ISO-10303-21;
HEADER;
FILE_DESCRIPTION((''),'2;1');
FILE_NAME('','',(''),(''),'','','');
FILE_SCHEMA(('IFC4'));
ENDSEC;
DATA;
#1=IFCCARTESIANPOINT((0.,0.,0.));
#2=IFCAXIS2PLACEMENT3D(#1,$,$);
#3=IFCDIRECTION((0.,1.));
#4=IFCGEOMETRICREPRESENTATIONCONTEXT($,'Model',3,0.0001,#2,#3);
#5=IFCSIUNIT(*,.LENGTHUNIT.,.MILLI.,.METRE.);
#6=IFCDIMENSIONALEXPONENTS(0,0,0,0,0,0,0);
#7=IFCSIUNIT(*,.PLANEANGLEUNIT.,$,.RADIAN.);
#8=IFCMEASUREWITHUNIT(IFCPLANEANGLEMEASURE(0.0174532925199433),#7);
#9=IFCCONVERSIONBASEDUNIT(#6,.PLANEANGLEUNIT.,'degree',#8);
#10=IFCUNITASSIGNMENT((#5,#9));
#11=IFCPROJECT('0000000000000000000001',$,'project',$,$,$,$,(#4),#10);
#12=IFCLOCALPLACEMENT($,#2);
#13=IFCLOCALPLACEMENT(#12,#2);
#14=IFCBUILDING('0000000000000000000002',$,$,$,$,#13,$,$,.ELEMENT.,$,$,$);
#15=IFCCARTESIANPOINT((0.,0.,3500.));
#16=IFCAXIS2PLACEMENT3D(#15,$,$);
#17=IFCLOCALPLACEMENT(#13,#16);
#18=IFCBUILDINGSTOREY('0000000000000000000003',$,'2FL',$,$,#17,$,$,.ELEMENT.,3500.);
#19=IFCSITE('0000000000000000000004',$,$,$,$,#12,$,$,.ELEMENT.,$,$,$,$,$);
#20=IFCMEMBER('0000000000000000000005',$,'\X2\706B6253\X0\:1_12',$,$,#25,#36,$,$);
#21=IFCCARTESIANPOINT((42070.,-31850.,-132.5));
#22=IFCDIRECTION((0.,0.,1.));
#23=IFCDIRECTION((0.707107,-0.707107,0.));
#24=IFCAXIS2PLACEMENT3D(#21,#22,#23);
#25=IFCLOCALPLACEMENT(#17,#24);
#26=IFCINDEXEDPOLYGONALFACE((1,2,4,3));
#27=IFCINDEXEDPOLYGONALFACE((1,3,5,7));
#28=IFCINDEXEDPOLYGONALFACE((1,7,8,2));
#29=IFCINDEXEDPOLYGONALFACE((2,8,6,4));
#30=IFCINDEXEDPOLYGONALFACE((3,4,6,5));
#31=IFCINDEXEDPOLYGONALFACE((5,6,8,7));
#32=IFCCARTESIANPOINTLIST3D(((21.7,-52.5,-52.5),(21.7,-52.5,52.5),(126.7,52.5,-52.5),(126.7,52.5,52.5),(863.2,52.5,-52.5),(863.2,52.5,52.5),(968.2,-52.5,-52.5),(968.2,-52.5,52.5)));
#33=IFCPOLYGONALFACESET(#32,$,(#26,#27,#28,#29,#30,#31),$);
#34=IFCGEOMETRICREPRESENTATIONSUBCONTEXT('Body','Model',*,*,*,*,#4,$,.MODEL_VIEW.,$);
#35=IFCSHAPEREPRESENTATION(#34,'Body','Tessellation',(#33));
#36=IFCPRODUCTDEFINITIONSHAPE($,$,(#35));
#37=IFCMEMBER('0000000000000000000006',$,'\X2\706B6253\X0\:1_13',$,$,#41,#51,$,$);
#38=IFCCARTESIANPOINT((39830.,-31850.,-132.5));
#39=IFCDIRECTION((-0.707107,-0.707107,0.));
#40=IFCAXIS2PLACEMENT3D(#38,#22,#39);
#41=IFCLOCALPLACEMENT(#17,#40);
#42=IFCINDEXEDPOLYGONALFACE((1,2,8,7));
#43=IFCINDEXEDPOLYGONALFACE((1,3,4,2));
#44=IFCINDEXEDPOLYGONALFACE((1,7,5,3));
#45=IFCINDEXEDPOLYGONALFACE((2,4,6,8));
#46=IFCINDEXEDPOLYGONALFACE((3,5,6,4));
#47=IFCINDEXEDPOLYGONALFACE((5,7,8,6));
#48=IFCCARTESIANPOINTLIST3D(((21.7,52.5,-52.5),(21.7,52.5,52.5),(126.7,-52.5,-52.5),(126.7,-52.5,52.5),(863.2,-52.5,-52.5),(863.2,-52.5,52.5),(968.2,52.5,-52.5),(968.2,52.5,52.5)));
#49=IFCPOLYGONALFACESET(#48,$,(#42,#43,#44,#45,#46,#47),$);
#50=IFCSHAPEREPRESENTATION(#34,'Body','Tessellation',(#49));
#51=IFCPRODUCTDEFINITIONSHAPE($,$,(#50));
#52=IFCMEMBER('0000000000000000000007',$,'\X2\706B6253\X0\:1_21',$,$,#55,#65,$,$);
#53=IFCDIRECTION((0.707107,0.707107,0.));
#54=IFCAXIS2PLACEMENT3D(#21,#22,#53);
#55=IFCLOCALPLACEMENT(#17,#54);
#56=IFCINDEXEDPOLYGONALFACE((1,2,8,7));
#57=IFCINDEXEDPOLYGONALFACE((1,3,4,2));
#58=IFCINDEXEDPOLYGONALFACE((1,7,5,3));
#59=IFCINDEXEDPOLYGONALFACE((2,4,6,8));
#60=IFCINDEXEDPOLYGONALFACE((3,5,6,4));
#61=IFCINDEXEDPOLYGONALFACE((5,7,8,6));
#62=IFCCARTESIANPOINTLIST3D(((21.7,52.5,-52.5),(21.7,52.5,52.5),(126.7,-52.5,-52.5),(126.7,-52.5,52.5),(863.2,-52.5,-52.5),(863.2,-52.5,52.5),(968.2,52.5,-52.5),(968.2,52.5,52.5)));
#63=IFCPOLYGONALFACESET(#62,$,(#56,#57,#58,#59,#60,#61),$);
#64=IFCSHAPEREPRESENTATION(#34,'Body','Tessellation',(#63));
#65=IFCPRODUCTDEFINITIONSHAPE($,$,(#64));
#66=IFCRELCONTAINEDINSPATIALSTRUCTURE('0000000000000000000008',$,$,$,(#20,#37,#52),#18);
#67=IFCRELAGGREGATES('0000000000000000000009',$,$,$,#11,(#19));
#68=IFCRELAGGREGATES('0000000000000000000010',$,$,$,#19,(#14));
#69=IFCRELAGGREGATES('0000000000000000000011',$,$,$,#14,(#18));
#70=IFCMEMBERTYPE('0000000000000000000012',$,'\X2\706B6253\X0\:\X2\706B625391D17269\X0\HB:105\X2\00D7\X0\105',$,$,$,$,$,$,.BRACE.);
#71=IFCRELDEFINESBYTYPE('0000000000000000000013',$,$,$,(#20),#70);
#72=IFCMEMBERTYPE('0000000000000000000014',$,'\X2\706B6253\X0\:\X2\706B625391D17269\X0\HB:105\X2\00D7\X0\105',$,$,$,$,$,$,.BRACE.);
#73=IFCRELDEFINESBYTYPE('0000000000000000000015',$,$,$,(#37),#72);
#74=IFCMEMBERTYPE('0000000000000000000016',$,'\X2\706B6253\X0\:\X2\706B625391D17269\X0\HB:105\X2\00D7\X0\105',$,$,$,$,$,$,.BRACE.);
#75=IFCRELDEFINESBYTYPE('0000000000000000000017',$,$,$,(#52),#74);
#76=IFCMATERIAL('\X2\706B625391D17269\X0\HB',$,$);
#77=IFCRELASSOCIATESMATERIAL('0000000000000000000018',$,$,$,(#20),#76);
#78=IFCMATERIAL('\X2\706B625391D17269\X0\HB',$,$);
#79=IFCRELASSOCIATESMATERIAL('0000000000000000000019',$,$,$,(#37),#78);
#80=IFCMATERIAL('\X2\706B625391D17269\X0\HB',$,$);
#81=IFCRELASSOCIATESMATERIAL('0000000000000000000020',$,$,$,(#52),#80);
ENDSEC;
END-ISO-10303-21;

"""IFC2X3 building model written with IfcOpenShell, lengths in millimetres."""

from ifc_helpers import new_model, entity, si_unit, converted_unit, direction, frame, origin, place, context, subcontext, project, spatial, polyline, outline, extrude, material, type_object, element, save


model = new_model("IFC2X3")

# Units and contexts
model_context = context("Model", 3, precision=0.0001, world=origin(), true_north=direction((0.0, 1.0)))
body_context = subcontext(model_context, "Body", "Model", "MODEL_VIEW")
ifc_project = project(units=[si_unit("LENGTHUNIT", "METRE", prefix="MILLI"), converted_unit("PLANEANGLEUNIT", "degree", entity("IfcPlaneAngleMeasure", 0.0174532925199433), si_unit("PLANEANGLEUNIT", "RADIAN"), dimensions=[0, 0, 0, 0, 0, 0, 0])], contexts=[model_context])

# Site, building, storey
site_placement = place(None, origin())
site = spatial("IfcSite", under=ifc_project, at=site_placement, CompositionType="ELEMENT")
building_placement = place(site_placement, origin())
building = spatial("IfcBuilding", under=site, at=building_placement, CompositionType="ELEMENT")
storey_placement = place(building_placement, frame((0.0, 0.0, 3500.0)))
storey = spatial("IfcBuildingStorey", under=building, at=storey_placement, Name="2FL", CompositionType="ELEMENT", Elevation=3500.0)

# Members
ifc_material_1 = material(Name="火打金物HB")
member_type_1 = type_object("IfcMemberType", Name="火打:火打金物HB:105×105", PredefinedType="BRACE")
member_1_placement = place(storey_placement, frame((42070.0, -31850.0, -132.5), z_axis=(0.0, 0.0, 1.0), x_axis=(0.707107, -0.707107, 0.0)))
element("IfcMember", 1, at=member_1_placement, inside=storey, type_object=member_type_1, material=ifc_material_1, Name="火打:1_12", context=body_context, shape_type="SweptSolid", body=[
    extrude(outline(polyline([(21.7, -52.5, 0.0), (126.7, 52.5, 0.0), (863.2, 52.5, 0.0), (968.2, -52.5, 0.0), (21.7, -52.5, 0.0)])), frame((0.0, 0.0, -52.5), z_axis=(0.0, 0.0, 1.0), x_axis=(1.0, 0.0, 0.0)), (0.0, 0.0, 1.0), 105.0),
])
ifc_material_2 = material(Name="火打金物HB")
member_type_2 = type_object("IfcMemberType", Name="火打:火打金物HB:105×105", PredefinedType="BRACE")
member_2_placement = place(storey_placement, frame((39830.0, -31850.0, -132.5), z_axis=(0.0, 0.0, 1.0), x_axis=(-0.707107, -0.707107, 0.0)))
element("IfcMember", 2, at=member_2_placement, inside=storey, type_object=member_type_2, material=ifc_material_2, Name="火打:1_13", context=body_context, shape_type="SweptSolid", body=[
    extrude(outline(polyline([(126.7, -52.5, 0.0), (21.7, 52.5, 0.0), (968.2, 52.5, 0.0), (863.2, -52.5, 0.0), (126.7, -52.5, 0.0)])), frame((0.0, 0.0, -52.5), z_axis=(0.0, 0.0, 1.0), x_axis=(1.0, 0.0, 0.0)), (0.0, 0.0, 1.0), 105.0),
])
ifc_material_3 = material(Name="火打金物HB")
member_type_3 = type_object("IfcMemberType", Name="火打:火打金物HB:105×105", PredefinedType="BRACE")
member_3_placement = place(storey_placement, frame((42070.0, -31850.0, -132.5), z_axis=(0.0, 0.0, 1.0), x_axis=(0.707107, 0.707107, 0.0)))
element("IfcMember", 3, at=member_3_placement, inside=storey, type_object=member_type_3, material=ifc_material_3, Name="火打:1_21", context=body_context, shape_type="SweptSolid", body=[
    extrude(outline(polyline([(126.7, -52.5, 0.0), (21.7, 52.5, 0.0), (968.2, 52.5, 0.0), (863.2, -52.5, 0.0), (126.7, -52.5, 0.0)])), frame((0.0, 0.0, -52.5), z_axis=(0.0, 0.0, 1.0), x_axis=(1.0, 0.0, 0.0)), (0.0, 0.0, 1.0), 105.0),
])

save(model, "model.ifc")
